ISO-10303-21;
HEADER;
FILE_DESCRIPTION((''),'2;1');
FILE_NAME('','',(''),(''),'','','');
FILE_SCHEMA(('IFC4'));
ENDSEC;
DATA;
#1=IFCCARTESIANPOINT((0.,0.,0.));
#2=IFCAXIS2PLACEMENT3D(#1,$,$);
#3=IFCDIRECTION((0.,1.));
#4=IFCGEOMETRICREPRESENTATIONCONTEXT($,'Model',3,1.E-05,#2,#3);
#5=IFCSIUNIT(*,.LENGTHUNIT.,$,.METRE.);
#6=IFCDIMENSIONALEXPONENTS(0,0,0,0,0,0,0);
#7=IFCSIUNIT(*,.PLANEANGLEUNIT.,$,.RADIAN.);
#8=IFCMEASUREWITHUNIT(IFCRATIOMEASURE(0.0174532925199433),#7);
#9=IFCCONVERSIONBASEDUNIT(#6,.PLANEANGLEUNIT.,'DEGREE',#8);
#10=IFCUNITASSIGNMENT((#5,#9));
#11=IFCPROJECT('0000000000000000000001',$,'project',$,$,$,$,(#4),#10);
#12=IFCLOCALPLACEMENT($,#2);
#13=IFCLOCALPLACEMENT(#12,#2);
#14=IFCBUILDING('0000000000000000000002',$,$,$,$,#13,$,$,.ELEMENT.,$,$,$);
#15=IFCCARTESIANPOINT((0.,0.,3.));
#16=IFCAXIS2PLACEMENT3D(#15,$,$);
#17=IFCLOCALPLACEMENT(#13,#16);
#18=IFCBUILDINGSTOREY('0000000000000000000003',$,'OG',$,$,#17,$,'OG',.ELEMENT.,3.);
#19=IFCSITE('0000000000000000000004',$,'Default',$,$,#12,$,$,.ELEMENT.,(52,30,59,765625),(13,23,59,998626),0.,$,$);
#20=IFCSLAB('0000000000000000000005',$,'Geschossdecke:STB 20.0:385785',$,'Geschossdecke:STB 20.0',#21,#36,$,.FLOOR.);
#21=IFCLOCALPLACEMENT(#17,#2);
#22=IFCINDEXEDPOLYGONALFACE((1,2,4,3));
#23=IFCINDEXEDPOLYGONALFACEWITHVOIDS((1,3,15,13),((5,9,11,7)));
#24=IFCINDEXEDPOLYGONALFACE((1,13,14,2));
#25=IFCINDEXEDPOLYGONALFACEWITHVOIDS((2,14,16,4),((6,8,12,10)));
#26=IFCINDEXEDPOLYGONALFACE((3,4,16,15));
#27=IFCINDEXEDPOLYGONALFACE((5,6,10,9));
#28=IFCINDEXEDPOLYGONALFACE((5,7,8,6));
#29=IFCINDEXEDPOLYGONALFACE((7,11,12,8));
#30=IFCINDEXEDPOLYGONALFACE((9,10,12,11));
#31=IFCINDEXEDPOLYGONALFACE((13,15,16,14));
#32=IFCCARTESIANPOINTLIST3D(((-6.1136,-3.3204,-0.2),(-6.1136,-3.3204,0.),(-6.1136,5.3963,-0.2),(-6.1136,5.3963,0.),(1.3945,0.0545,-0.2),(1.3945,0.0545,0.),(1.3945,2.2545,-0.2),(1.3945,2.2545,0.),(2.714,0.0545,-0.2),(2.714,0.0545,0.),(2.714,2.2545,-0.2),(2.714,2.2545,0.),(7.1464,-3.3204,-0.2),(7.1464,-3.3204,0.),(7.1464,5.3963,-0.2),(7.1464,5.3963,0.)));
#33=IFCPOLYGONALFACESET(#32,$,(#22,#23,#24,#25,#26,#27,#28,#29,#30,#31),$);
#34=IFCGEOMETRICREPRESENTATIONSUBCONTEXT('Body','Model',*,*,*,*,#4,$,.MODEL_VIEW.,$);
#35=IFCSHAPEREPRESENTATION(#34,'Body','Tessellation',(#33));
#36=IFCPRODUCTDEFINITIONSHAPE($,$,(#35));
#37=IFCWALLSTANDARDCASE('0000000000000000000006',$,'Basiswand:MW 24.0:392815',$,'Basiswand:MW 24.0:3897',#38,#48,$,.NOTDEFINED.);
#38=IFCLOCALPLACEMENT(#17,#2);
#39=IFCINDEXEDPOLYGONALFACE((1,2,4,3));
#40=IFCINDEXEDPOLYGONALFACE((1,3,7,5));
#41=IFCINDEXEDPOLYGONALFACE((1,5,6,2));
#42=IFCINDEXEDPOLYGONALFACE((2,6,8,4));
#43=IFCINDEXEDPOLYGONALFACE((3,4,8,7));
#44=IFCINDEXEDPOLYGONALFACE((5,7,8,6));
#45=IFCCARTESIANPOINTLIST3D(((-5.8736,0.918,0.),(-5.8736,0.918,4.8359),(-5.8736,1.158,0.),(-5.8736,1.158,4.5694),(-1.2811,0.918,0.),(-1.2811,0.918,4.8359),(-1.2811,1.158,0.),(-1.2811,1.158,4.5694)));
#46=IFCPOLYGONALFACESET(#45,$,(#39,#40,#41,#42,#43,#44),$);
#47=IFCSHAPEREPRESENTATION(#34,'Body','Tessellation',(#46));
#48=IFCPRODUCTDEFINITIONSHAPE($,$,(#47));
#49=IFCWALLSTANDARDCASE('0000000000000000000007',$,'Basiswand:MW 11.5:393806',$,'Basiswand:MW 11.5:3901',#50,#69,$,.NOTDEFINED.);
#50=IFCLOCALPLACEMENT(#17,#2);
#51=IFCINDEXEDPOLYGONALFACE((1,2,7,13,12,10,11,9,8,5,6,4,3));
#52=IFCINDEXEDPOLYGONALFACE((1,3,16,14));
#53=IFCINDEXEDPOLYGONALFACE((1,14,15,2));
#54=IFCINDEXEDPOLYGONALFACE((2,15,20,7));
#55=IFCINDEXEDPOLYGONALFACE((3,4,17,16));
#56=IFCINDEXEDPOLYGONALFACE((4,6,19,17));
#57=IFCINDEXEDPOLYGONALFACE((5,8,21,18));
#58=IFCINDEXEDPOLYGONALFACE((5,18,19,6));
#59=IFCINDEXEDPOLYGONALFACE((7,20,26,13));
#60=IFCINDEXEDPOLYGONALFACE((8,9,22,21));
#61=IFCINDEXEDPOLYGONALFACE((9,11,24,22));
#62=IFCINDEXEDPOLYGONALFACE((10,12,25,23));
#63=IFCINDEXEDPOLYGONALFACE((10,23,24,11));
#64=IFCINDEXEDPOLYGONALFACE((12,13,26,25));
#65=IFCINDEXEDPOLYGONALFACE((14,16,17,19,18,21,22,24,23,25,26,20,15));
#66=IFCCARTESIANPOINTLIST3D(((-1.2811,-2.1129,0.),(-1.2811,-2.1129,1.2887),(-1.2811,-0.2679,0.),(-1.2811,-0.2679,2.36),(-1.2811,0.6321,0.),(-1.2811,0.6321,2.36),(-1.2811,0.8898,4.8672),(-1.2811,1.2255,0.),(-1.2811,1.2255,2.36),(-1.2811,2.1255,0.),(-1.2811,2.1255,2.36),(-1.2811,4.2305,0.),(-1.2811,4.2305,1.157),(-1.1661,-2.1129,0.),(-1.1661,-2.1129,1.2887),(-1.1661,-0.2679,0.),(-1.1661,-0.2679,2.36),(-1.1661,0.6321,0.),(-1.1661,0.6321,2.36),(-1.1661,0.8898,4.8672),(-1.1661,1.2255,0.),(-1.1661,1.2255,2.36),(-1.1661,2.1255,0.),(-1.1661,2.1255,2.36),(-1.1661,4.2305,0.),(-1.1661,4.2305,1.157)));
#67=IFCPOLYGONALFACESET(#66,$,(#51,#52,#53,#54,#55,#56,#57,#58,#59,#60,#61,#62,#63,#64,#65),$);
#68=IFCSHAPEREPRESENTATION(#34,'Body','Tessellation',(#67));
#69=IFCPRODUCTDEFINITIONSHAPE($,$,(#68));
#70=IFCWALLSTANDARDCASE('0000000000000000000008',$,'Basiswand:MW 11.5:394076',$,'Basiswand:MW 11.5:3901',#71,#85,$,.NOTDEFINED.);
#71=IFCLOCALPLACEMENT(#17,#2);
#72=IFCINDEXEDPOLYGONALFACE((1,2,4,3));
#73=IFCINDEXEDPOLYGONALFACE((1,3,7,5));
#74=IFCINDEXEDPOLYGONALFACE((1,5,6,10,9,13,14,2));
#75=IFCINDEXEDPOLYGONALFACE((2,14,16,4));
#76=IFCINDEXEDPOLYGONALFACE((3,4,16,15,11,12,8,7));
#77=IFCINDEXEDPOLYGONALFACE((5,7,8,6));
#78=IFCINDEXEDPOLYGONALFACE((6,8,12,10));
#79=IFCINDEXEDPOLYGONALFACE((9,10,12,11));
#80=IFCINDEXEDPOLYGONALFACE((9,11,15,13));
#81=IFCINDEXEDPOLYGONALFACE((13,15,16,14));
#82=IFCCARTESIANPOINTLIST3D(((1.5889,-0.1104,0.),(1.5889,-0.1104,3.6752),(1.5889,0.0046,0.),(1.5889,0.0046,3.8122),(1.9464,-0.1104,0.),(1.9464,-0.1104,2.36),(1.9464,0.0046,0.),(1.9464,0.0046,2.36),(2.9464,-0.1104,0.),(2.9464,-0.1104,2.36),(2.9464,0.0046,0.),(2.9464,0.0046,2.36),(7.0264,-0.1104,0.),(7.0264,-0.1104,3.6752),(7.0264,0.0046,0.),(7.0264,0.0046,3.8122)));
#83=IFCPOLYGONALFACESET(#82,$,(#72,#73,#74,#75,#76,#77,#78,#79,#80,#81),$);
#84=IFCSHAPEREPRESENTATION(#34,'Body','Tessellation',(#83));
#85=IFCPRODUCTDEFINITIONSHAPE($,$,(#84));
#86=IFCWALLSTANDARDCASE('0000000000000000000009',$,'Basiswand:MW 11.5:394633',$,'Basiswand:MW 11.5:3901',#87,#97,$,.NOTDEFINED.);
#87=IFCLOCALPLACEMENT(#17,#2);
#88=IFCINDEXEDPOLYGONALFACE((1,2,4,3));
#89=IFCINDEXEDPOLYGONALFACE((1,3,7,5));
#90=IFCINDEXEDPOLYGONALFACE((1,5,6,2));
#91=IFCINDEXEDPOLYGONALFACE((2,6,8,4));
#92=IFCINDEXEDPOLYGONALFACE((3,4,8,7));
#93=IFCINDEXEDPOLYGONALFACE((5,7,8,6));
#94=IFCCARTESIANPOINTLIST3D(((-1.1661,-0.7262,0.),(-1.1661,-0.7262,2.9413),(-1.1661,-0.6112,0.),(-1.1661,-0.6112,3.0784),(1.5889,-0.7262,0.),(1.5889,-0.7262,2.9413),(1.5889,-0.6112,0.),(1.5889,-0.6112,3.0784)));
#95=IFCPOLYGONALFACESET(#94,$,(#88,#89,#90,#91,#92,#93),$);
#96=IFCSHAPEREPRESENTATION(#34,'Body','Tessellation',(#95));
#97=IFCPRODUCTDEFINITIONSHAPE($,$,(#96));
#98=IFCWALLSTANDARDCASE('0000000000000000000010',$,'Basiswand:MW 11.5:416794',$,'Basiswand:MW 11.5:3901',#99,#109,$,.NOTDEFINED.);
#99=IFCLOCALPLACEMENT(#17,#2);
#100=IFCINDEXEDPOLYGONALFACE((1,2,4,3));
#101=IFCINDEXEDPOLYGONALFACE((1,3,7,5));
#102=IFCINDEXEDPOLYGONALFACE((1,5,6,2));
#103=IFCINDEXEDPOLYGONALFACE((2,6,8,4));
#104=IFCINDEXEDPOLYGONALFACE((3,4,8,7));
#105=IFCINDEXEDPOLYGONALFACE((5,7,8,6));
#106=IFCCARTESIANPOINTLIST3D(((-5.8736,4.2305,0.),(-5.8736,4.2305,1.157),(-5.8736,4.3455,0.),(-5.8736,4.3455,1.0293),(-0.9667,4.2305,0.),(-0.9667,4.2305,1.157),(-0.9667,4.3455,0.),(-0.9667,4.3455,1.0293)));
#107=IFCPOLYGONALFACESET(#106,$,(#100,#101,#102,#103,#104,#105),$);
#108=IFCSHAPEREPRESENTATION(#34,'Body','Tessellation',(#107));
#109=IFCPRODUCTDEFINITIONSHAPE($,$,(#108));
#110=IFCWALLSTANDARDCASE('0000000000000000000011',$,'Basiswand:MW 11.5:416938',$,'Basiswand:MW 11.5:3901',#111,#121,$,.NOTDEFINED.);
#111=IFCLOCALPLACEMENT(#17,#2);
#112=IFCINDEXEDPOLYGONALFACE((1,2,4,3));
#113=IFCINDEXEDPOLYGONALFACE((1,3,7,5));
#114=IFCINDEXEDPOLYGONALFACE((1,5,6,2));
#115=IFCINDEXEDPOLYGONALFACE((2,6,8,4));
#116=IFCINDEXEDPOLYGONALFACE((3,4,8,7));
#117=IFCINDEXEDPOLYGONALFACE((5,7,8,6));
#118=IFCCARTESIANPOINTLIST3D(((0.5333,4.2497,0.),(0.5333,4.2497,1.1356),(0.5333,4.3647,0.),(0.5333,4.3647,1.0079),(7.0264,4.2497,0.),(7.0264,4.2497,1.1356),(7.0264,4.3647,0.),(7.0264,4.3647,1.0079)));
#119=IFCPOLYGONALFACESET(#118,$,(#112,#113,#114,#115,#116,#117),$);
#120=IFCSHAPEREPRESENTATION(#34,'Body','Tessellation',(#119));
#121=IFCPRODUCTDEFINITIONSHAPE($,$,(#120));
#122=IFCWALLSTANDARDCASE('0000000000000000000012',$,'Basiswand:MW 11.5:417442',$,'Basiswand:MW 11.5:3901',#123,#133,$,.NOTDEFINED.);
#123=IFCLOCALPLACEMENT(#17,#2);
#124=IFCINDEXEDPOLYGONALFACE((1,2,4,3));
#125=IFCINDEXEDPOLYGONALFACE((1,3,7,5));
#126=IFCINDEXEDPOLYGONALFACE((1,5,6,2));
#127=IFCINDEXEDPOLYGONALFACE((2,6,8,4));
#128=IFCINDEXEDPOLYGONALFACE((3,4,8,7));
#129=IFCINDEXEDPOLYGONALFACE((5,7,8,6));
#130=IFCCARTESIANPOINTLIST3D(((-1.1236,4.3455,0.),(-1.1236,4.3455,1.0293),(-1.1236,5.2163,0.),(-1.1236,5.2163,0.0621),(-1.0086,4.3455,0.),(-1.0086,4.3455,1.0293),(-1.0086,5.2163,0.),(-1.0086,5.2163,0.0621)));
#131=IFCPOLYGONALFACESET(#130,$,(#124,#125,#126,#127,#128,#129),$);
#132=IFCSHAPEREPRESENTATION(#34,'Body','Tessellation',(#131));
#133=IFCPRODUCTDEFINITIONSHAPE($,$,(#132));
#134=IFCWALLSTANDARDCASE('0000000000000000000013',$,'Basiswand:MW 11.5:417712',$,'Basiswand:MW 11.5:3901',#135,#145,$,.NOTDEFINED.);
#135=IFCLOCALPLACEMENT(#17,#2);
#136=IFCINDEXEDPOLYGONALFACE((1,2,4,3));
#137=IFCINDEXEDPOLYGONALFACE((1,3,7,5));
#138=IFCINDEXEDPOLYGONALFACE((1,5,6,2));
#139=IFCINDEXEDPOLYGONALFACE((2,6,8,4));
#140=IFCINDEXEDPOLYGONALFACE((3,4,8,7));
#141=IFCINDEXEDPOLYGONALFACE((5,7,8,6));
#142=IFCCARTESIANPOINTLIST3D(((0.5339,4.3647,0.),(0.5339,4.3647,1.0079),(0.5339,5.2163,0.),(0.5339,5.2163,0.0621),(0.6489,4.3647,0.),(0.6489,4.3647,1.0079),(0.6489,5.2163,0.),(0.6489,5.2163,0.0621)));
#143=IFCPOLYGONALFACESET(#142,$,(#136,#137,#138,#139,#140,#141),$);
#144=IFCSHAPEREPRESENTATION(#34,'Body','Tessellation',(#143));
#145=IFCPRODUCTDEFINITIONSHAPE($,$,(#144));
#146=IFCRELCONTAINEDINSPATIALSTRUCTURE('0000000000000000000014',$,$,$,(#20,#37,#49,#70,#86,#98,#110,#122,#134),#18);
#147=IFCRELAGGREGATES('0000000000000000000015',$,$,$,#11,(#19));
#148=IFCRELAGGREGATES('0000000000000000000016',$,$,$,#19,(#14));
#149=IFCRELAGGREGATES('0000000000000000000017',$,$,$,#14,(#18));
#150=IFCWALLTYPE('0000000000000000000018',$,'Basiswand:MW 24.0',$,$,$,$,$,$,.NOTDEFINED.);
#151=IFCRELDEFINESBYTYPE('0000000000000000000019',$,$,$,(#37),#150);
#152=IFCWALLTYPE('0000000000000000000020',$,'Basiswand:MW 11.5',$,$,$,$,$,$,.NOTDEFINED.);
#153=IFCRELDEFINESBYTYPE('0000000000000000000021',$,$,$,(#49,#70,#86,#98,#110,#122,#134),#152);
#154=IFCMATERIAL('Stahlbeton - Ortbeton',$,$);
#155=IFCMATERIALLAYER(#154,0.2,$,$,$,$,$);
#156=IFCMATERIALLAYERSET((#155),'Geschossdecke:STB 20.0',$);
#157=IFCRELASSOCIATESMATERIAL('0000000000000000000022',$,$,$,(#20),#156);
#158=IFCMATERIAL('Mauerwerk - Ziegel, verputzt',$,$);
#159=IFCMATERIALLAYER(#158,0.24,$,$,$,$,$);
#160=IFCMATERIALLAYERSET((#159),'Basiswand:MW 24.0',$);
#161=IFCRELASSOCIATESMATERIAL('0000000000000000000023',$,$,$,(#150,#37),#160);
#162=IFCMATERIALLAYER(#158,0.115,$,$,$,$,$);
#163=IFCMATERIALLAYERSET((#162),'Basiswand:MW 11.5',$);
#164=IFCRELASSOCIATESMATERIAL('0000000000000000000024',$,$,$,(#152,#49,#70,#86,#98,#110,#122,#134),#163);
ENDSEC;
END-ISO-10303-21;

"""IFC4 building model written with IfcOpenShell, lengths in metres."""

from ifc_helpers import new_model, entity, si_unit, converted_unit, direction, frame, frame_2d, origin, place, context, subcontext, project, spatial, polyline, rectangle, extrude, clip, bounded_halfspace, material, layer, layer_set, layer_usage, type_object, element, save


model = new_model("IFC4")

# Units and contexts
model_context = context("Model", 3, precision=1e-05, world=origin(), true_north=direction((0.0, 1.0)))
body_context = subcontext(model_context, "Body", "Model", "MODEL_VIEW")
ifc_project = project(units=[si_unit("LENGTHUNIT", "METRE"), converted_unit("PLANEANGLEUNIT", "DEGREE", entity("IfcRatioMeasure", 0.0174532925199433), si_unit("PLANEANGLEUNIT", "RADIAN"), dimensions=[0, 0, 0, 0, 0, 0, 0])], contexts=[model_context])

# Site, building, storey
site_placement = place(None, origin())
site = spatial("IfcSite", under=ifc_project, at=site_placement, Name="Default", CompositionType="ELEMENT", RefLatitude=(52, 30, 59, 765625), RefLongitude=(13, 23, 59, 998626), RefElevation=0.0)
building_placement = place(site_placement, origin())
building = spatial("IfcBuilding", under=site, at=building_placement, CompositionType="ELEMENT")
storey_placement = place(building_placement, frame((0.0, 0.0, 3.0)))
storey = spatial("IfcBuildingStorey", under=building, at=storey_placement, Name="OG", LongName="OG", CompositionType="ELEMENT", Elevation=3.0)

# Slab, opening
ifc_material_1 = material(Name="Stahlbeton - Ortbeton")
ifc_layer_1 = layer(ifc_material_1, 0.2)
ifc_layer_set_1 = layer_set([ifc_layer_1], Name="Geschossdecke:STB 20.0")
ifc_layer_usage_1 = layer_usage(ifc_layer_set_1, "AXIS3", "POSITIVE", 0.0)
slab_placement = place(storey_placement, frame((-6.1136, -3.3204, -0.2)))
slab = element("IfcSlab", 1, at=slab_placement, inside=storey, material=ifc_layer_usage_1, Name="Geschossdecke:STB 20.0:385785", ObjectType="Geschossdecke:STB 20.0", PredefinedType="FLOOR", context=body_context, shape_type="SweptSolid", body=[
    extrude(rectangle(XDim=8.7167, YDim=13.26, at=frame_2d((0.0, 0.0), x_axis=(0.0, -1.0))), frame((6.63, 4.3584, 0.2), z_axis=(0.0, 0.0, -1.0), x_axis=(-1.0, 0.0, 0.0)), (0.0, 0.0, 1.0), 0.2),
])
opening_1_placement = place(storey_placement, frame((-6.1136, -3.3204, -0.2)))
element("IfcOpeningElement", 2, at=opening_1_placement, cuts=slab, ObjectType="Opening", context=body_context, shape_type="SweptSolid", body=[
    extrude(rectangle(XDim=2.2, YDim=1.3195, at=frame_2d((-1.5379, 0.1165), x_axis=(0.0, 1.0))), frame((6.63, 4.3584, 0.2), z_axis=(0.0, 0.0, -1.0), x_axis=(-1.0, 0.0, 0.0)), (0.0, 0.0, 1.0), 0.2),
])

# Wall
ifc_material_2 = material(Name="Mauerwerk - Ziegel, verputzt")
ifc_layer_2 = layer(ifc_material_2, 0.24)
ifc_layer_set_2 = layer_set([ifc_layer_2], Name="Basiswand:MW 24.0")
ifc_layer_usage_2 = layer_usage(ifc_layer_set_2, "AXIS2", "NEGATIVE", 0.12)
wall_type_1 = type_object("IfcWallType", Name="Basiswand:MW 24.0", PredefinedType="NOTDEFINED", material=ifc_layer_set_2)
wall_1_placement = place(storey_placement, frame((-5.8736, 1.038, 0.0)))
element("IfcWallStandardCase", 3, at=wall_1_placement, inside=storey, type_object=wall_type_1, material=ifc_layer_usage_2, Name="Basiswand:MW 24.0:392815", ObjectType="Basiswand:MW 24.0:3897", PredefinedType="NOTDEFINED", context=body_context, shape_type="Clipping", body=[
    clip(extrude(rectangle(XDim=4.5925, YDim=0.24, at=frame_2d((2.2963, 0.0), x_axis=(-1.0, 0.0))), origin(), (0.0, 0.0, 1.0), 4.8359), bounded_halfspace(frame((0.0, -0.12, 4.8359), z_axis=(0.0, -0.743145, -0.669131), x_axis=(-1.0, 0.0, 0.0)), True, frame((0.0, -0.12, 4.8359)), polyline([(0.0, 0.0), (4.5925, 0.0), (4.5925, 0.24), (0.0, 0.24), (0.0, 0.0)]))),
])

# Wall, openings
ifc_layer_3 = layer(ifc_material_2, 0.115)
ifc_layer_set_3 = layer_set([ifc_layer_3], Name="Basiswand:MW 11.5")
ifc_layer_usage_3 = layer_usage(ifc_layer_set_3, "AXIS2", "NEGATIVE", 0.0575)
wall_type_2 = type_object("IfcWallType", Name="Basiswand:MW 11.5", PredefinedType="NOTDEFINED", material=ifc_layer_set_3)
wall_2_placement = place(storey_placement, frame((-1.2236, -2.1129, 0.0), z_axis=(0.0, 0.0, 1.0), x_axis=(0.0, 1.0, 0.0)))
wall_2 = element("IfcWallStandardCase", 4, at=wall_2_placement, inside=storey, type_object=wall_type_2, material=ifc_layer_usage_3, Name="Basiswand:MW 11.5:393806", ObjectType="Basiswand:MW 11.5:3901", PredefinedType="NOTDEFINED", context=body_context, shape_type="Clipping", body=[
    clip(clip(extrude(rectangle(XDim=6.3434, YDim=0.115, at=frame_2d((3.1717, 0.0), x_axis=(-1.0, 0.0))), origin(), (0.0, 0.0, 1.0), 4.8672), bounded_halfspace(frame((0.0, -0.0575, 1.2887), z_axis=(0.766044, 0.0, -0.642788), x_axis=(0.0, 1.0, 0.0)), True, frame((0.0, -0.0575, 1.2887)), polyline([(0.0, 0.0), (1.3867, 0.0), (1.5017, 0.0), (3.0027, 0.0), (3.0027, 0.115), (0.0, 0.115), (0.0, 0.0)]))), bounded_halfspace(frame((3.0027, -0.0575, 4.8672), z_axis=(-0.743145, 0.0, -0.669131), x_axis=(0.0, 1.0, 0.0)), True, frame((3.0027, -0.0575, 4.8672)), polyline([(0.0, 0.0), (3.3407, 0.0), (3.3407, 0.115), (0.0, 0.115), (0.0, 0.0)]))),
])
opening_2_placement = place(wall_2_placement, frame((3.3384, -0.0575, 0.0)))
element("IfcOpeningElement", 5, at=opening_2_placement, cuts=wall_2, ObjectType="Opening", PredefinedType="OPENING", context=body_context, shape_type="SweptSolid", body=[
    extrude(rectangle(XDim=2.36, YDim=0.9, at=frame_2d((1.18, 0.45), x_axis=(1.0, 0.0))), frame((0.0, 0.0, 0.0), z_axis=(0.0, 1.0, 0.0), x_axis=(0.0, 0.0, 1.0)), (0.0, 0.0, 1.0), 0.115),
])
opening_3_placement = place(wall_2_placement, frame((1.845, -0.0575, 0.0)))
element("IfcOpeningElement", 6, at=opening_3_placement, cuts=wall_2, ObjectType="Opening", PredefinedType="OPENING", context=body_context, shape_type="SweptSolid", body=[
    extrude(rectangle(XDim=2.36, YDim=0.9, at=frame_2d((1.18, 0.45), x_axis=(1.0, 0.0))), frame((0.0, 0.0, 0.0), z_axis=(0.0, 1.0, 0.0), x_axis=(0.0, 0.0, 1.0)), (0.0, 0.0, 1.0), 0.115),
])

# Wall, opening
ifc_layer_usage_4 = layer_usage(ifc_layer_set_3, "AXIS2", "NEGATIVE", 0.0575)
wall_3_placement = place(storey_placement, frame((1.5889, -0.0529, 0.0)))
wall_3 = element("IfcWallStandardCase", 7, at=wall_3_placement, inside=storey, type_object=wall_type_2, material=ifc_layer_usage_4, Name="Basiswand:MW 11.5:394076", ObjectType="Basiswand:MW 11.5:3901", PredefinedType="NOTDEFINED", context=body_context, shape_type="Clipping", body=[
    clip(extrude(rectangle(XDim=5.4375, YDim=0.115, at=frame_2d((2.7188, 0.0), x_axis=(-1.0, 0.0))), origin(), (0.0, 0.0, 1.0), 3.8122), bounded_halfspace(frame((0.0, -0.0575, 3.6752), z_axis=(0.0, 0.766044, -0.642788), x_axis=(-1.0, 0.0, 0.0)), True, frame((0.0, -0.0575, 3.6752)), polyline([(0.0, 0.0), (0.115, 0.0), (5.4375, 0.0), (5.4375, 0.115), (1.715, 0.115), (1.6, 0.115), (0.0, 0.115), (0.0, 0.0)]))),
])
opening_4_placement = place(wall_3_placement, frame((1.3575, 0.0575, 0.0)))
element("IfcOpeningElement", 8, at=opening_4_placement, cuts=wall_3, ObjectType="Opening", PredefinedType="OPENING", context=body_context, shape_type="SweptSolid", body=[
    extrude(rectangle(XDim=2.36, YDim=1.0, at=frame_2d((1.18, 0.5), x_axis=(1.0, 0.0))), frame((0.0, 0.0, 0.0), z_axis=(0.0, -1.0, 0.0), x_axis=(0.0, 0.0, 1.0)), (0.0, 0.0, 1.0), 0.115),
])

# Walls
ifc_layer_usage_5 = layer_usage(ifc_layer_set_3, "AXIS2", "POSITIVE", -0.0575)
wall_4_placement = place(storey_placement, frame((-1.1661, -0.6687, 0.0)))
element("IfcWallStandardCase", 9, at=wall_4_placement, inside=storey, type_object=wall_type_2, material=ifc_layer_usage_5, Name="Basiswand:MW 11.5:394633", ObjectType="Basiswand:MW 11.5:3901", PredefinedType="NOTDEFINED", context=body_context, shape_type="Clipping", body=[
    clip(extrude(rectangle(XDim=2.755, YDim=0.115, at=frame_2d((1.3775, 0.0), x_axis=(-1.0, 0.0))), origin(), (0.0, 0.0, 1.0), 3.0784), bounded_halfspace(frame((0.0, -0.0575, 2.9413), z_axis=(0.0, 0.766044, -0.642788), x_axis=(-1.0, 0.0, 0.0)), True, frame((0.0, -0.0575, 2.9413)), polyline([(0.0, 0.0), (2.755, 0.0), (2.755, 0.115), (0.0, 0.115), (0.0, 0.0)]))),
])
ifc_layer_usage_6 = layer_usage(ifc_layer_set_3, "AXIS2", "NEGATIVE", 0.0575)
wall_5_placement = place(storey_placement, frame((-0.9667, 4.288, 0.0), z_axis=(0.0, 0.0, 1.0), x_axis=(-1.0, 0.0, 0.0)))
element("IfcWallStandardCase", 10, at=wall_5_placement, inside=storey, type_object=wall_type_2, material=ifc_layer_usage_6, Name="Basiswand:MW 11.5:416794", ObjectType="Basiswand:MW 11.5:3901", PredefinedType="NOTDEFINED", context=body_context, shape_type="Clipping", body=[
    clip(extrude(rectangle(XDim=4.9069, YDim=0.115, at=frame_2d((2.4534, 0.0), x_axis=(-1.0, 0.0))), origin(), (0.0, 0.0, 1.0), 1.157), bounded_halfspace(frame((0.0, -0.0575, 1.0293), z_axis=(0.0, 0.743145, -0.669131), x_axis=(1.0, 0.0, 0.0)), True, frame((0.0, -0.0575, 1.0293)), polyline([(0.0, 0.0), (4.9069, 0.0), (4.9069, 0.115), (0.0, 0.115), (0.0, 0.0)]))),
])
ifc_layer_usage_7 = layer_usage(ifc_layer_set_3, "AXIS2", "NEGATIVE", 0.0575)
wall_6_placement = place(storey_placement, frame((0.5333, 4.3072, 0.0)))
element("IfcWallStandardCase", 11, at=wall_6_placement, inside=storey, type_object=wall_type_2, material=ifc_layer_usage_7, Name="Basiswand:MW 11.5:416938", ObjectType="Basiswand:MW 11.5:3901", PredefinedType="NOTDEFINED", context=body_context, shape_type="Clipping", body=[
    clip(extrude(rectangle(XDim=6.4931, YDim=0.115, at=frame_2d((3.2466, 0.0), x_axis=(-1.0, 0.0))), origin(), (0.0, 0.0, 1.0), 1.1356), bounded_halfspace(frame((0.0, -0.0575, 1.1356), z_axis=(0.0, -0.743145, -0.669131), x_axis=(-1.0, 0.0, 0.0)), True, frame((0.0, -0.0575, 1.1356)), polyline([(0.0, 0.0), (6.4931, 0.0), (6.4931, 0.115), (0.0, 0.115), (0.0, 0.0)]))),
])
ifc_layer_usage_8 = layer_usage(ifc_layer_set_3, "AXIS2", "NEGATIVE", 0.0575)
wall_7_placement = place(storey_placement, frame((-1.0661, 4.3455, 0.0), z_axis=(0.0, 0.0, 1.0), x_axis=(0.0, 1.0, 0.0)))
element("IfcWallStandardCase", 12, at=wall_7_placement, inside=storey, type_object=wall_type_2, material=ifc_layer_usage_8, Name="Basiswand:MW 11.5:417442", ObjectType="Basiswand:MW 11.5:3901", PredefinedType="NOTDEFINED", context=body_context, shape_type="Clipping", body=[
    clip(extrude(rectangle(XDim=0.8709, YDim=0.115, at=frame_2d((0.4354, 0.0), x_axis=(-1.0, 0.0))), origin(), (0.0, 0.0, 1.0), 1.0293), bounded_halfspace(frame((0.0, -0.0575, 1.0293), z_axis=(-0.743145, 0.0, -0.669131), x_axis=(0.0, 1.0, 0.0)), True, frame((0.0, -0.0575, 1.0293)), polyline([(0.0, 0.0), (0.8709, 0.0), (0.8709, 0.115), (0.0, 0.115), (0.0, 0.0)]))),
])
ifc_layer_usage_9 = layer_usage(ifc_layer_set_3, "AXIS2", "NEGATIVE", 0.0575)
wall_8_placement = place(storey_placement, frame((0.5914, 4.3647, 0.0), z_axis=(0.0, 0.0, 1.0), x_axis=(0.0, 1.0, 0.0)))
element("IfcWallStandardCase", 13, at=wall_8_placement, inside=storey, type_object=wall_type_2, material=ifc_layer_usage_9, Name="Basiswand:MW 11.5:417712", ObjectType="Basiswand:MW 11.5:3901", PredefinedType="NOTDEFINED", context=body_context, shape_type="Clipping", body=[
    clip(extrude(rectangle(XDim=0.8516, YDim=0.115, at=frame_2d((0.4258, 0.0), x_axis=(-1.0, 0.0))), origin(), (0.0, 0.0, 1.0), 1.0079), bounded_halfspace(frame((0.0, -0.0575, 1.0079), z_axis=(-0.743145, 0.0, -0.669131), x_axis=(0.0, 1.0, 0.0)), True, frame((0.0, -0.0575, 1.0079)), polyline([(0.0, 0.0), (0.8516, 0.0), (0.8516, 0.115), (0.0, 0.115), (0.0, 0.0)]))),
])

save(model, "model.ifc")
